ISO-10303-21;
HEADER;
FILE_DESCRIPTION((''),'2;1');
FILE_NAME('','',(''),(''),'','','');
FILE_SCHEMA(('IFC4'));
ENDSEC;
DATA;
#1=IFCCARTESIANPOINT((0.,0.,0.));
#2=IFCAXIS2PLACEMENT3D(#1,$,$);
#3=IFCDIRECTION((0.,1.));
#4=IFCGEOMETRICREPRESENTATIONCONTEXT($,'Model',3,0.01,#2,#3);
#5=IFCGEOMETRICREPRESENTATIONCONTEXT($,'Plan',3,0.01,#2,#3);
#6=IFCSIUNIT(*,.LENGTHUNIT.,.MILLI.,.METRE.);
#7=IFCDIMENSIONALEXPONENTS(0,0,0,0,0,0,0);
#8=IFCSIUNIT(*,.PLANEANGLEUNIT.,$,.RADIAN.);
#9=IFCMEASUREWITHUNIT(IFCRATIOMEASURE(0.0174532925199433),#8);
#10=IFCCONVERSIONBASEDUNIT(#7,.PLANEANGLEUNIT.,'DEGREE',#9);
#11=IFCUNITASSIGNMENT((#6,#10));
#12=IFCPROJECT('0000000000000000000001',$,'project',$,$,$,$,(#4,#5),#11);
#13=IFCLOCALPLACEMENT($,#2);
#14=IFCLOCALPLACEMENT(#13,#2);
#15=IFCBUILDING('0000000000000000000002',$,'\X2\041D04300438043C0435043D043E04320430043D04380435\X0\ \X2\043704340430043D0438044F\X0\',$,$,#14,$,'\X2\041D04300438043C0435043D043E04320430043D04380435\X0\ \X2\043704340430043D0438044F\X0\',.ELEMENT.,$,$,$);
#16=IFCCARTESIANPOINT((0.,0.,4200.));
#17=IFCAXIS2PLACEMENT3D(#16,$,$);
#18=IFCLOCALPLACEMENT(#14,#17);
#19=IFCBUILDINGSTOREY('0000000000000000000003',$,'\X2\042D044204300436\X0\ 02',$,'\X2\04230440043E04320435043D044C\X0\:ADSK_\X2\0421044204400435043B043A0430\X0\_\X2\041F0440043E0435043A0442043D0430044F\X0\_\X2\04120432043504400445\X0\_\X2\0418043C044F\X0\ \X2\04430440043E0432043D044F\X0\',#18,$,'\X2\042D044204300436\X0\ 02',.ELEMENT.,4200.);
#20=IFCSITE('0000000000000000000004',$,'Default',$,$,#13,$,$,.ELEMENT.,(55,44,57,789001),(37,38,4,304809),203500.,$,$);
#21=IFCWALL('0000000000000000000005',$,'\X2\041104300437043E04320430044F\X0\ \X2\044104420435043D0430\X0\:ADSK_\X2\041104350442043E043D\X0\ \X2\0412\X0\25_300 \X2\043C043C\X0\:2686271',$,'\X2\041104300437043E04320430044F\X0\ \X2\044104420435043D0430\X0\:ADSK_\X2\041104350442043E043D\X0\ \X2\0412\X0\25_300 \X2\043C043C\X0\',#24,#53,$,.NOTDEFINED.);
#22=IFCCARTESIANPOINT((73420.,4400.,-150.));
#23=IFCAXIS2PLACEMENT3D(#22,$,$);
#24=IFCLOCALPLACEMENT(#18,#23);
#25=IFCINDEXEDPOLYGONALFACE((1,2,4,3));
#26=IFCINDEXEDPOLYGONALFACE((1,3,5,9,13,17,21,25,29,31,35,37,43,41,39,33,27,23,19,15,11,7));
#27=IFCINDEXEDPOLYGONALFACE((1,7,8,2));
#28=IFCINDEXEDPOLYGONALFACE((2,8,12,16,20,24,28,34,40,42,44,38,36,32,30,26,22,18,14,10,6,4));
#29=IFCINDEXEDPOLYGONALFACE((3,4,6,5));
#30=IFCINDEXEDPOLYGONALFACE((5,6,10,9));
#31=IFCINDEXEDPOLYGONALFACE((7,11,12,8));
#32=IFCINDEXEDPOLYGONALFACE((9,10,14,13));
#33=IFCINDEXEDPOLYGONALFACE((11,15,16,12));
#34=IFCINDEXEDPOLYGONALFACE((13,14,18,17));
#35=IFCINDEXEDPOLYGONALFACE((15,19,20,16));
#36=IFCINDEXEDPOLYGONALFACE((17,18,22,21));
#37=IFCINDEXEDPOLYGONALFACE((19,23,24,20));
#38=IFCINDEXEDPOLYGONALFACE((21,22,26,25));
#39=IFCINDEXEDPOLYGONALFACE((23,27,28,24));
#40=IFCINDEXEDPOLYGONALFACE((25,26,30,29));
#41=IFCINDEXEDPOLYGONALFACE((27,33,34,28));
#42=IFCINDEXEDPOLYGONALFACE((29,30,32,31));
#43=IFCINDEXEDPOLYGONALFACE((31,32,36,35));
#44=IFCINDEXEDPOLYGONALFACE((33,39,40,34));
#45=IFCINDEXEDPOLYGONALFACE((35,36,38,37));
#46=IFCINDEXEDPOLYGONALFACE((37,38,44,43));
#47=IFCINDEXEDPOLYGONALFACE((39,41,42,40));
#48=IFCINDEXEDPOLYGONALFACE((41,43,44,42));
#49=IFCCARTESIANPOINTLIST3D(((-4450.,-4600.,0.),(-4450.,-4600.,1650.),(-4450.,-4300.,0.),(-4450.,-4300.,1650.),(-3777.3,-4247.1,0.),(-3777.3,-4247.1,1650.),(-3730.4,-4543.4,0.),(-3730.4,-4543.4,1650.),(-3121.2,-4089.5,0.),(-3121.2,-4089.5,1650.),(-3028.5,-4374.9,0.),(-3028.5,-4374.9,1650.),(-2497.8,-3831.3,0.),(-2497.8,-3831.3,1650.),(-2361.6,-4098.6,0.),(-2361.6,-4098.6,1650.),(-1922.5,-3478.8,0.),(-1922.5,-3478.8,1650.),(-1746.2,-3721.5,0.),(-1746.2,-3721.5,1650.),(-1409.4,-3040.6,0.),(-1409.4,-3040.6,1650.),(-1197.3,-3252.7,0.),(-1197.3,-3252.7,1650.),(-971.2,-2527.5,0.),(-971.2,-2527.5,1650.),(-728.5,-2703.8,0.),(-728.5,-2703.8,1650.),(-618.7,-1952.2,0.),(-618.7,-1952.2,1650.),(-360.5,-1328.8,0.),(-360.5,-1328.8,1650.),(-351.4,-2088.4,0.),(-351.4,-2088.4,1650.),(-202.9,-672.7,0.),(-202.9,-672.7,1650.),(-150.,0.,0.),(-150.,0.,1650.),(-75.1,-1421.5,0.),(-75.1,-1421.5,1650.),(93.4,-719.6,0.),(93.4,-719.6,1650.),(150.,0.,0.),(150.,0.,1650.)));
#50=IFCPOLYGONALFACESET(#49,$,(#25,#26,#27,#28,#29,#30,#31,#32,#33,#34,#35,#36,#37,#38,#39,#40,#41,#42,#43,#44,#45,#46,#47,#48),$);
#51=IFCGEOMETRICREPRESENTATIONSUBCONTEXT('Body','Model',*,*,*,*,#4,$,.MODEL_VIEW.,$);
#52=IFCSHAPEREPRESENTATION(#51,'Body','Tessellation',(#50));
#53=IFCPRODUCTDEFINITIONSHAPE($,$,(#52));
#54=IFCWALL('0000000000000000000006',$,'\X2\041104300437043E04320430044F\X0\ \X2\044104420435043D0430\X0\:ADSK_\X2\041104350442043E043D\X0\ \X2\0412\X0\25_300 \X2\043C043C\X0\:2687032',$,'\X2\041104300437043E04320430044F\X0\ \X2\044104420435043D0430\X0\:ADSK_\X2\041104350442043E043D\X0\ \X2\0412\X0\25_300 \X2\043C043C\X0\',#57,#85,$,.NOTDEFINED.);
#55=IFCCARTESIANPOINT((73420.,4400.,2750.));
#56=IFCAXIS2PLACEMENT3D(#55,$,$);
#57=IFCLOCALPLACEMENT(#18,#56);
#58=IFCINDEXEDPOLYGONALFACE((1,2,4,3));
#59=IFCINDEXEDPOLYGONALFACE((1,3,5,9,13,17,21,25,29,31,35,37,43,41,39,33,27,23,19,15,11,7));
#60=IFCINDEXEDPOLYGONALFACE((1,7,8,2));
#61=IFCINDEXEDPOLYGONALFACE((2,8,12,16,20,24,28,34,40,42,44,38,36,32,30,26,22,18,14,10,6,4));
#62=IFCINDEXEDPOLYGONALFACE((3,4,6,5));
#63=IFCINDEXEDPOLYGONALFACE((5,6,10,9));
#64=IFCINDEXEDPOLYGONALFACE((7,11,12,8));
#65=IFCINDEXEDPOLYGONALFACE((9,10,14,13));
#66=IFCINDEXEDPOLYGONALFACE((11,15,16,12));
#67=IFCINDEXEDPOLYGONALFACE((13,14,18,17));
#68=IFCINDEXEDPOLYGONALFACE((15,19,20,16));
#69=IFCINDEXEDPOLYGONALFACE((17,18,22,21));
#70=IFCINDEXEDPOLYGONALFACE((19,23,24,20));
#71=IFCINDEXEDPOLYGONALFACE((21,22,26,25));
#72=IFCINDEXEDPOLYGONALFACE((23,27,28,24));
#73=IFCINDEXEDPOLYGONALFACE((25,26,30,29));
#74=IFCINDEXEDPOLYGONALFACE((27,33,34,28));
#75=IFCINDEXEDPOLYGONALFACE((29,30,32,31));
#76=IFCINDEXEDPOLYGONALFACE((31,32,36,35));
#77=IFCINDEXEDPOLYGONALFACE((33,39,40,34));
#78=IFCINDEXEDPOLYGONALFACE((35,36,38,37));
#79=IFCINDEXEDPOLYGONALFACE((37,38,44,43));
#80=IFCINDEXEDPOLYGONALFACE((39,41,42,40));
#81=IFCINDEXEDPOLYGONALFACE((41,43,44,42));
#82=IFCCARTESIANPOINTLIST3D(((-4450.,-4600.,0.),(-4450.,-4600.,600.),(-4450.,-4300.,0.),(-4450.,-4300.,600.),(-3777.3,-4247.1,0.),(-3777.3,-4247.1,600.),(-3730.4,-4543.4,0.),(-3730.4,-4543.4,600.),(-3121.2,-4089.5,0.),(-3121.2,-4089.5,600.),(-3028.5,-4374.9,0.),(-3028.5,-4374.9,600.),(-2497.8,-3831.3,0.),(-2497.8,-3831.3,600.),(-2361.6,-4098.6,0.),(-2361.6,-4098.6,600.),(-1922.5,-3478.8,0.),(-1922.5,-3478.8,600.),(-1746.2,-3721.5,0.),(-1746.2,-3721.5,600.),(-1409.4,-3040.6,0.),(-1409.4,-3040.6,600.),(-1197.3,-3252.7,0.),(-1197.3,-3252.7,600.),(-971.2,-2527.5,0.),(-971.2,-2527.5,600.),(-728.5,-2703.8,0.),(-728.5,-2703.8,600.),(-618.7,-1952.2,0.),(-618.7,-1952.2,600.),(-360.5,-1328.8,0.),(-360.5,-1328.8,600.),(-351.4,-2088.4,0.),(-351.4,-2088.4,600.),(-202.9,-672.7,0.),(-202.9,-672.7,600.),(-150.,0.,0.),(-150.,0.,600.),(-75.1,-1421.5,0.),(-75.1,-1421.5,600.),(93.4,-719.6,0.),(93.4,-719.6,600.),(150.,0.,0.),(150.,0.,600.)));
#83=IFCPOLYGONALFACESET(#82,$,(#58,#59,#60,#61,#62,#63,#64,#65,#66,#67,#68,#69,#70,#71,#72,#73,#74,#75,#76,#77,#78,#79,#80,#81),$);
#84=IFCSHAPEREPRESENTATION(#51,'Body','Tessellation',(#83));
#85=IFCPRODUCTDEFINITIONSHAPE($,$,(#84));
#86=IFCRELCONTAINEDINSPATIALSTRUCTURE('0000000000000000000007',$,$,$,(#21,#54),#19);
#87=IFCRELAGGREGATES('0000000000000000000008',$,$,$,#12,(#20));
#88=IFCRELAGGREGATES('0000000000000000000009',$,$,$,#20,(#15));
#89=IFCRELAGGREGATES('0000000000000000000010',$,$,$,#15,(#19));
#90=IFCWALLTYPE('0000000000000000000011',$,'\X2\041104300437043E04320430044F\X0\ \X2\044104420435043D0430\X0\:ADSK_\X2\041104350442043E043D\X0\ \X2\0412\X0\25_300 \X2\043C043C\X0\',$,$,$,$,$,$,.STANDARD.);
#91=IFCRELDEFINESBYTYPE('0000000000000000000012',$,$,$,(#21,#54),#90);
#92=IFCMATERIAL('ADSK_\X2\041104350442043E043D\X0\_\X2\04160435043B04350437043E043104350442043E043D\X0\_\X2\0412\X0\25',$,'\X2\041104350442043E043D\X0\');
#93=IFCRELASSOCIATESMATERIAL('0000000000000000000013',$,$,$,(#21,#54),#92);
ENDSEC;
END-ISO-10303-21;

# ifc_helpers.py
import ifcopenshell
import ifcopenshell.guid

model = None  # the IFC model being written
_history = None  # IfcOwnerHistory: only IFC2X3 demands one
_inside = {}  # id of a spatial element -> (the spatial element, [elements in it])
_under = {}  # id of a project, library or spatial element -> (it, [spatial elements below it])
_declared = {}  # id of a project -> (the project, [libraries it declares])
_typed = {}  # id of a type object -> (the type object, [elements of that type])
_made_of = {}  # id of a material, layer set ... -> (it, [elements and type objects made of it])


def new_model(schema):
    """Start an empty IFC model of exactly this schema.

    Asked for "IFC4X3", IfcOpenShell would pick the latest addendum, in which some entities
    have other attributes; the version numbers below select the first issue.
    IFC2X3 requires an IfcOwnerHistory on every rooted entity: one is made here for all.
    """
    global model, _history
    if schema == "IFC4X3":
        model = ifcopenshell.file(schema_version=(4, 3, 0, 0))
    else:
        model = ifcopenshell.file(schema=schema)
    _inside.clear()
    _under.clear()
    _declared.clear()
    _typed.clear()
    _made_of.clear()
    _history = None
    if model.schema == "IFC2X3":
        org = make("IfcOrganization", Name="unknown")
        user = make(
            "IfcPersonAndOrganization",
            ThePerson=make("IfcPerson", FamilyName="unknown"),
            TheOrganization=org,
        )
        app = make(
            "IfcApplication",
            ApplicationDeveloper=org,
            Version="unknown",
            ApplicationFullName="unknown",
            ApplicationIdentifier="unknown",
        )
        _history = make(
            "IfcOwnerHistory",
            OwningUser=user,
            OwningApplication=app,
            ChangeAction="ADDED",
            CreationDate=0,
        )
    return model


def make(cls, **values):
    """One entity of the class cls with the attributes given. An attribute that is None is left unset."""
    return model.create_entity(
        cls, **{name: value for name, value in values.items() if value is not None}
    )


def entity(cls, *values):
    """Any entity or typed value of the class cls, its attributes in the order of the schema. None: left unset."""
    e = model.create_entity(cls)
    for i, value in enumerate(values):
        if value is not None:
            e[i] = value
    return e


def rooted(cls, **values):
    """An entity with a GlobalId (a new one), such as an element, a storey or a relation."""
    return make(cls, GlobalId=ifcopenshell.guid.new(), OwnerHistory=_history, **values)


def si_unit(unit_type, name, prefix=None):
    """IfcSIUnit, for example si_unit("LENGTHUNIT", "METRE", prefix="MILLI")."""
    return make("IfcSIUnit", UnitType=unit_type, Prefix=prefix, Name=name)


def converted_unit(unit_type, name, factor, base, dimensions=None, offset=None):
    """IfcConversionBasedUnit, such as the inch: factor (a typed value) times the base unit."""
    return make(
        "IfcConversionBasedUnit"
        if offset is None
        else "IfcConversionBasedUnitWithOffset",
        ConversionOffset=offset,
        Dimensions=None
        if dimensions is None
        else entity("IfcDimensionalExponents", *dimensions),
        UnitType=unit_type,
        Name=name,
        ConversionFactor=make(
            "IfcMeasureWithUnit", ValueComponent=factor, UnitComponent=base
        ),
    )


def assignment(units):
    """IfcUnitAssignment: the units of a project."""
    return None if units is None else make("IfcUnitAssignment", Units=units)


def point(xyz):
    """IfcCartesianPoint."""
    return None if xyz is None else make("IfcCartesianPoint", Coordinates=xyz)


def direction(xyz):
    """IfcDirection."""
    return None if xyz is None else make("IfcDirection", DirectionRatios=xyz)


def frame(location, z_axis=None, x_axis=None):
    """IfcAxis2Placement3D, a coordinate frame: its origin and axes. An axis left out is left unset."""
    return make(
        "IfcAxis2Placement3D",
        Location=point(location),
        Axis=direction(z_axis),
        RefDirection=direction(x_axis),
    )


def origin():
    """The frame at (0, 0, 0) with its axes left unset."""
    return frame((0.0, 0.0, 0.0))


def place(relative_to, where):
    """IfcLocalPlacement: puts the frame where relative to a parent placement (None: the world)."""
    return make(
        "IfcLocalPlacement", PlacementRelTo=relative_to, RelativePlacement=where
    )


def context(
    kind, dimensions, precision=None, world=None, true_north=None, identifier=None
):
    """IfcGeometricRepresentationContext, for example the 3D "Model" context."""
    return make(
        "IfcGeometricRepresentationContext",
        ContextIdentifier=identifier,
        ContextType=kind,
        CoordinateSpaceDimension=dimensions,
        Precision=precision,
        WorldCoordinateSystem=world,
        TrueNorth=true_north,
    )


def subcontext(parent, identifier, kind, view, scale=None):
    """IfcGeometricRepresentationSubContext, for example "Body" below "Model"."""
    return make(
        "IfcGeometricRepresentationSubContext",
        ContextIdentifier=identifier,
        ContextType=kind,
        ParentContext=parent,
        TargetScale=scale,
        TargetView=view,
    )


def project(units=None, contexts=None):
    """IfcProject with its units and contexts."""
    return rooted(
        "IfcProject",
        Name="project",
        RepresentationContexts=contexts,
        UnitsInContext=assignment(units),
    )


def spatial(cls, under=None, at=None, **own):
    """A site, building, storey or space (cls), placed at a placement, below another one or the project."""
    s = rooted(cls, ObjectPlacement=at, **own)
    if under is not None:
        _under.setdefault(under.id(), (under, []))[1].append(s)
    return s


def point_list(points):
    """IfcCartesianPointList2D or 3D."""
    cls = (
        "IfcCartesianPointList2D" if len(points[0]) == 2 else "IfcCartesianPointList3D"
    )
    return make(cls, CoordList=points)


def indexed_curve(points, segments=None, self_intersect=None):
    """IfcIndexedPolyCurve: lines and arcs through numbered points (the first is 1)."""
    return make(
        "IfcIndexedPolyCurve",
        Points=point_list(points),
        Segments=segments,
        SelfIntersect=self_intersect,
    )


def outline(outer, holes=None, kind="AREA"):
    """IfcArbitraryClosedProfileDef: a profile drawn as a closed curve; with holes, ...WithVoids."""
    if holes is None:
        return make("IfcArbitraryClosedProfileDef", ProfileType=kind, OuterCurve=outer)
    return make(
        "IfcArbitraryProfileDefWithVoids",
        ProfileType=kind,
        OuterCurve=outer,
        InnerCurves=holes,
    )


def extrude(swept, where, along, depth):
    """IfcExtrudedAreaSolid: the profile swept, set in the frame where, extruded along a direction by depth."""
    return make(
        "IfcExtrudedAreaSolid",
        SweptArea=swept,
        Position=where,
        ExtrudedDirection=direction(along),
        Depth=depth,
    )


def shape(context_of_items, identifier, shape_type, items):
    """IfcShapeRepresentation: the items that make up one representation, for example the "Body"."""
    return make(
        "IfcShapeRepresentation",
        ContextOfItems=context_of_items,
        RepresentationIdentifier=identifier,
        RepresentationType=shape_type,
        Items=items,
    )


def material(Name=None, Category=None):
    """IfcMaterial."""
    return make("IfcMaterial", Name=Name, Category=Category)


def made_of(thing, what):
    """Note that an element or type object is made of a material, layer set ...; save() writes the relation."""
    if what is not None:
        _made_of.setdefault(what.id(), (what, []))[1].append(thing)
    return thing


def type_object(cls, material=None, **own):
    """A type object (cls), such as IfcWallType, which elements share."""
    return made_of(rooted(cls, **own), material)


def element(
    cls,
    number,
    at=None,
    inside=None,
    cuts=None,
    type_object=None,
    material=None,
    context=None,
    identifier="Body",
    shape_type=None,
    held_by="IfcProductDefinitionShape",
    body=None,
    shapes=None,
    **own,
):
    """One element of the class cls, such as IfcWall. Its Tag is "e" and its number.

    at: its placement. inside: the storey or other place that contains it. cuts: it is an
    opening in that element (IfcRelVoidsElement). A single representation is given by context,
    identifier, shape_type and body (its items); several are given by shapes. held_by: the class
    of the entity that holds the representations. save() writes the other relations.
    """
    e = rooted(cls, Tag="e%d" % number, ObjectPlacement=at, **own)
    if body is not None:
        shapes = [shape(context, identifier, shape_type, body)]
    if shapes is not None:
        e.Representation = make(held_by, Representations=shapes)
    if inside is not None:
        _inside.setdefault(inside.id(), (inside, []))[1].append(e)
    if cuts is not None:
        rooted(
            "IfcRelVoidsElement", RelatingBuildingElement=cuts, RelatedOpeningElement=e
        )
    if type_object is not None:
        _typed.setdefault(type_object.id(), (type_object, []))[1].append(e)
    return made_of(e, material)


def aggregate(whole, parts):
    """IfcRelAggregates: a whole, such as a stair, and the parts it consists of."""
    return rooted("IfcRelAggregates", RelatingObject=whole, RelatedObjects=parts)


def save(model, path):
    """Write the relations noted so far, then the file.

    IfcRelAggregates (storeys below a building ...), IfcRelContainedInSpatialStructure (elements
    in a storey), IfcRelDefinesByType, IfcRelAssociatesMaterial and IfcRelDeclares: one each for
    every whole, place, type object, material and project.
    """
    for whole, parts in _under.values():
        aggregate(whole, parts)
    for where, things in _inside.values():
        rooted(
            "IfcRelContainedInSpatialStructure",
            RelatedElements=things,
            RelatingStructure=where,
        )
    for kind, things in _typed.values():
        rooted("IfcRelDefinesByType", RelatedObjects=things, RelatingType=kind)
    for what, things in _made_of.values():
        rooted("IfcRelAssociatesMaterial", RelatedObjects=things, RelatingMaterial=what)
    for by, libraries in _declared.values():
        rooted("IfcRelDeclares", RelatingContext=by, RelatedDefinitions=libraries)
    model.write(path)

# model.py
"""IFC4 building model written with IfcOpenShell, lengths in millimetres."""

from ifc_helpers import new_model, entity, si_unit, converted_unit, direction, frame, origin, place, context, subcontext, project, spatial, indexed_curve, outline, extrude, material, type_object, element, save


model = new_model("IFC4")

# Units and contexts
model_context = context("Model", 3, precision=0.01, world=origin(), true_north=direction((0.0, 1.0)))
plan_context = context("Plan", 3, precision=0.01, world=origin(), true_north=direction((0.0, 1.0)))
body_context = subcontext(model_context, "Body", "Model", "MODEL_VIEW")
ifc_project = project(units=[si_unit("LENGTHUNIT", "METRE", prefix="MILLI"), converted_unit("PLANEANGLEUNIT", "DEGREE", entity("IfcRatioMeasure", 0.0174532925199433), si_unit("PLANEANGLEUNIT", "RADIAN"), dimensions=[0, 0, 0, 0, 0, 0, 0])], contexts=[model_context, plan_context])

# Site, building, storey
site_placement = place(None, origin())
site = spatial("IfcSite", under=ifc_project, at=site_placement, Name="Default", CompositionType="ELEMENT", RefLatitude=(55, 44, 57, 789001), RefLongitude=(37, 38, 4, 304809), RefElevation=203500.0)
building_placement = place(site_placement, origin())
building = spatial("IfcBuilding", under=site, at=building_placement, Name="Наименование здания", LongName="Наименование здания", CompositionType="ELEMENT")
storey_placement = place(building_placement, frame((0.0, 0.0, 4200.0)))
storey = spatial("IfcBuildingStorey", under=building, at=storey_placement, Name="Этаж 02", ObjectType="Уровень:ADSK_Стрелка_Проектная_Вверх_Имя уровня", LongName="Этаж 02", CompositionType="ELEMENT", Elevation=4200.0)

# Walls
ifc_material = material(Name="ADSK_Бетон_Железобетон_В25", Category="Бетон")
wall_type_1 = type_object("IfcWallType", Name="Базовая стена:ADSK_Бетон В25_300 мм", PredefinedType="STANDARD")
wall_1_placement = place(storey_placement, frame((73420.0, 4400.0, -150.0)))
element("IfcWall", 1, at=wall_1_placement, inside=storey, type_object=wall_type_1, material=ifc_material, Name="Базовая стена:ADSK_Бетон В25_300 мм:2686271", ObjectType="Базовая стена:ADSK_Бетон В25_300 мм", PredefinedType="NOTDEFINED", context=body_context, shape_type="SweptSolid", body=[
    extrude(outline(indexed_curve([(-4450.0, -4600.0), (-3730.4, -4543.4), (-3028.5, -4374.9), (-2361.6, -4098.6), (-1746.2, -3721.5), (-1197.3, -3252.7), (-728.5, -2703.8), (-351.4, -2088.4), (-75.1, -1421.5), (93.4, -719.6), (150.0, 0.0), (-150.0, 0.0), (-202.9, -672.7), (-360.5, -1328.8), (-618.7, -1952.2), (-971.2, -2527.5), (-1409.4, -3040.6), (-1922.5, -3478.8), (-2497.8, -3831.3), (-3121.2, -4089.5), (-3777.3, -4247.1), (-4450.0, -4300.0), (-4450.0, -4600.0)], self_intersect=False)), origin(), (0.0, 0.0, 1.0), 1650.0),
])
wall_2_placement = place(storey_placement, frame((73420.0, 4400.0, 2750.0)))
element("IfcWall", 2, at=wall_2_placement, inside=storey, type_object=wall_type_1, material=ifc_material, Name="Базовая стена:ADSK_Бетон В25_300 мм:2687032", ObjectType="Базовая стена:ADSK_Бетон В25_300 мм", PredefinedType="NOTDEFINED", context=body_context, shape_type="SweptSolid", body=[
    extrude(outline(indexed_curve([(-4450.0, -4600.0), (-3730.4, -4543.4), (-3028.5, -4374.9), (-2361.6, -4098.6), (-1746.2, -3721.5), (-1197.3, -3252.7), (-728.5, -2703.8), (-351.4, -2088.4), (-75.1, -1421.5), (93.4, -719.6), (150.0, 0.0), (-150.0, 0.0), (-202.9, -672.7), (-360.5, -1328.8), (-618.7, -1952.2), (-971.2, -2527.5), (-1409.4, -3040.6), (-1922.5, -3478.8), (-2497.8, -3831.3), (-3121.2, -4089.5), (-3777.3, -4247.1), (-4450.0, -4300.0), (-4450.0, -4600.0)], self_intersect=False)), origin(), (0.0, 0.0, 1.0), 600.0),
])

save(model, "model.ifc")
